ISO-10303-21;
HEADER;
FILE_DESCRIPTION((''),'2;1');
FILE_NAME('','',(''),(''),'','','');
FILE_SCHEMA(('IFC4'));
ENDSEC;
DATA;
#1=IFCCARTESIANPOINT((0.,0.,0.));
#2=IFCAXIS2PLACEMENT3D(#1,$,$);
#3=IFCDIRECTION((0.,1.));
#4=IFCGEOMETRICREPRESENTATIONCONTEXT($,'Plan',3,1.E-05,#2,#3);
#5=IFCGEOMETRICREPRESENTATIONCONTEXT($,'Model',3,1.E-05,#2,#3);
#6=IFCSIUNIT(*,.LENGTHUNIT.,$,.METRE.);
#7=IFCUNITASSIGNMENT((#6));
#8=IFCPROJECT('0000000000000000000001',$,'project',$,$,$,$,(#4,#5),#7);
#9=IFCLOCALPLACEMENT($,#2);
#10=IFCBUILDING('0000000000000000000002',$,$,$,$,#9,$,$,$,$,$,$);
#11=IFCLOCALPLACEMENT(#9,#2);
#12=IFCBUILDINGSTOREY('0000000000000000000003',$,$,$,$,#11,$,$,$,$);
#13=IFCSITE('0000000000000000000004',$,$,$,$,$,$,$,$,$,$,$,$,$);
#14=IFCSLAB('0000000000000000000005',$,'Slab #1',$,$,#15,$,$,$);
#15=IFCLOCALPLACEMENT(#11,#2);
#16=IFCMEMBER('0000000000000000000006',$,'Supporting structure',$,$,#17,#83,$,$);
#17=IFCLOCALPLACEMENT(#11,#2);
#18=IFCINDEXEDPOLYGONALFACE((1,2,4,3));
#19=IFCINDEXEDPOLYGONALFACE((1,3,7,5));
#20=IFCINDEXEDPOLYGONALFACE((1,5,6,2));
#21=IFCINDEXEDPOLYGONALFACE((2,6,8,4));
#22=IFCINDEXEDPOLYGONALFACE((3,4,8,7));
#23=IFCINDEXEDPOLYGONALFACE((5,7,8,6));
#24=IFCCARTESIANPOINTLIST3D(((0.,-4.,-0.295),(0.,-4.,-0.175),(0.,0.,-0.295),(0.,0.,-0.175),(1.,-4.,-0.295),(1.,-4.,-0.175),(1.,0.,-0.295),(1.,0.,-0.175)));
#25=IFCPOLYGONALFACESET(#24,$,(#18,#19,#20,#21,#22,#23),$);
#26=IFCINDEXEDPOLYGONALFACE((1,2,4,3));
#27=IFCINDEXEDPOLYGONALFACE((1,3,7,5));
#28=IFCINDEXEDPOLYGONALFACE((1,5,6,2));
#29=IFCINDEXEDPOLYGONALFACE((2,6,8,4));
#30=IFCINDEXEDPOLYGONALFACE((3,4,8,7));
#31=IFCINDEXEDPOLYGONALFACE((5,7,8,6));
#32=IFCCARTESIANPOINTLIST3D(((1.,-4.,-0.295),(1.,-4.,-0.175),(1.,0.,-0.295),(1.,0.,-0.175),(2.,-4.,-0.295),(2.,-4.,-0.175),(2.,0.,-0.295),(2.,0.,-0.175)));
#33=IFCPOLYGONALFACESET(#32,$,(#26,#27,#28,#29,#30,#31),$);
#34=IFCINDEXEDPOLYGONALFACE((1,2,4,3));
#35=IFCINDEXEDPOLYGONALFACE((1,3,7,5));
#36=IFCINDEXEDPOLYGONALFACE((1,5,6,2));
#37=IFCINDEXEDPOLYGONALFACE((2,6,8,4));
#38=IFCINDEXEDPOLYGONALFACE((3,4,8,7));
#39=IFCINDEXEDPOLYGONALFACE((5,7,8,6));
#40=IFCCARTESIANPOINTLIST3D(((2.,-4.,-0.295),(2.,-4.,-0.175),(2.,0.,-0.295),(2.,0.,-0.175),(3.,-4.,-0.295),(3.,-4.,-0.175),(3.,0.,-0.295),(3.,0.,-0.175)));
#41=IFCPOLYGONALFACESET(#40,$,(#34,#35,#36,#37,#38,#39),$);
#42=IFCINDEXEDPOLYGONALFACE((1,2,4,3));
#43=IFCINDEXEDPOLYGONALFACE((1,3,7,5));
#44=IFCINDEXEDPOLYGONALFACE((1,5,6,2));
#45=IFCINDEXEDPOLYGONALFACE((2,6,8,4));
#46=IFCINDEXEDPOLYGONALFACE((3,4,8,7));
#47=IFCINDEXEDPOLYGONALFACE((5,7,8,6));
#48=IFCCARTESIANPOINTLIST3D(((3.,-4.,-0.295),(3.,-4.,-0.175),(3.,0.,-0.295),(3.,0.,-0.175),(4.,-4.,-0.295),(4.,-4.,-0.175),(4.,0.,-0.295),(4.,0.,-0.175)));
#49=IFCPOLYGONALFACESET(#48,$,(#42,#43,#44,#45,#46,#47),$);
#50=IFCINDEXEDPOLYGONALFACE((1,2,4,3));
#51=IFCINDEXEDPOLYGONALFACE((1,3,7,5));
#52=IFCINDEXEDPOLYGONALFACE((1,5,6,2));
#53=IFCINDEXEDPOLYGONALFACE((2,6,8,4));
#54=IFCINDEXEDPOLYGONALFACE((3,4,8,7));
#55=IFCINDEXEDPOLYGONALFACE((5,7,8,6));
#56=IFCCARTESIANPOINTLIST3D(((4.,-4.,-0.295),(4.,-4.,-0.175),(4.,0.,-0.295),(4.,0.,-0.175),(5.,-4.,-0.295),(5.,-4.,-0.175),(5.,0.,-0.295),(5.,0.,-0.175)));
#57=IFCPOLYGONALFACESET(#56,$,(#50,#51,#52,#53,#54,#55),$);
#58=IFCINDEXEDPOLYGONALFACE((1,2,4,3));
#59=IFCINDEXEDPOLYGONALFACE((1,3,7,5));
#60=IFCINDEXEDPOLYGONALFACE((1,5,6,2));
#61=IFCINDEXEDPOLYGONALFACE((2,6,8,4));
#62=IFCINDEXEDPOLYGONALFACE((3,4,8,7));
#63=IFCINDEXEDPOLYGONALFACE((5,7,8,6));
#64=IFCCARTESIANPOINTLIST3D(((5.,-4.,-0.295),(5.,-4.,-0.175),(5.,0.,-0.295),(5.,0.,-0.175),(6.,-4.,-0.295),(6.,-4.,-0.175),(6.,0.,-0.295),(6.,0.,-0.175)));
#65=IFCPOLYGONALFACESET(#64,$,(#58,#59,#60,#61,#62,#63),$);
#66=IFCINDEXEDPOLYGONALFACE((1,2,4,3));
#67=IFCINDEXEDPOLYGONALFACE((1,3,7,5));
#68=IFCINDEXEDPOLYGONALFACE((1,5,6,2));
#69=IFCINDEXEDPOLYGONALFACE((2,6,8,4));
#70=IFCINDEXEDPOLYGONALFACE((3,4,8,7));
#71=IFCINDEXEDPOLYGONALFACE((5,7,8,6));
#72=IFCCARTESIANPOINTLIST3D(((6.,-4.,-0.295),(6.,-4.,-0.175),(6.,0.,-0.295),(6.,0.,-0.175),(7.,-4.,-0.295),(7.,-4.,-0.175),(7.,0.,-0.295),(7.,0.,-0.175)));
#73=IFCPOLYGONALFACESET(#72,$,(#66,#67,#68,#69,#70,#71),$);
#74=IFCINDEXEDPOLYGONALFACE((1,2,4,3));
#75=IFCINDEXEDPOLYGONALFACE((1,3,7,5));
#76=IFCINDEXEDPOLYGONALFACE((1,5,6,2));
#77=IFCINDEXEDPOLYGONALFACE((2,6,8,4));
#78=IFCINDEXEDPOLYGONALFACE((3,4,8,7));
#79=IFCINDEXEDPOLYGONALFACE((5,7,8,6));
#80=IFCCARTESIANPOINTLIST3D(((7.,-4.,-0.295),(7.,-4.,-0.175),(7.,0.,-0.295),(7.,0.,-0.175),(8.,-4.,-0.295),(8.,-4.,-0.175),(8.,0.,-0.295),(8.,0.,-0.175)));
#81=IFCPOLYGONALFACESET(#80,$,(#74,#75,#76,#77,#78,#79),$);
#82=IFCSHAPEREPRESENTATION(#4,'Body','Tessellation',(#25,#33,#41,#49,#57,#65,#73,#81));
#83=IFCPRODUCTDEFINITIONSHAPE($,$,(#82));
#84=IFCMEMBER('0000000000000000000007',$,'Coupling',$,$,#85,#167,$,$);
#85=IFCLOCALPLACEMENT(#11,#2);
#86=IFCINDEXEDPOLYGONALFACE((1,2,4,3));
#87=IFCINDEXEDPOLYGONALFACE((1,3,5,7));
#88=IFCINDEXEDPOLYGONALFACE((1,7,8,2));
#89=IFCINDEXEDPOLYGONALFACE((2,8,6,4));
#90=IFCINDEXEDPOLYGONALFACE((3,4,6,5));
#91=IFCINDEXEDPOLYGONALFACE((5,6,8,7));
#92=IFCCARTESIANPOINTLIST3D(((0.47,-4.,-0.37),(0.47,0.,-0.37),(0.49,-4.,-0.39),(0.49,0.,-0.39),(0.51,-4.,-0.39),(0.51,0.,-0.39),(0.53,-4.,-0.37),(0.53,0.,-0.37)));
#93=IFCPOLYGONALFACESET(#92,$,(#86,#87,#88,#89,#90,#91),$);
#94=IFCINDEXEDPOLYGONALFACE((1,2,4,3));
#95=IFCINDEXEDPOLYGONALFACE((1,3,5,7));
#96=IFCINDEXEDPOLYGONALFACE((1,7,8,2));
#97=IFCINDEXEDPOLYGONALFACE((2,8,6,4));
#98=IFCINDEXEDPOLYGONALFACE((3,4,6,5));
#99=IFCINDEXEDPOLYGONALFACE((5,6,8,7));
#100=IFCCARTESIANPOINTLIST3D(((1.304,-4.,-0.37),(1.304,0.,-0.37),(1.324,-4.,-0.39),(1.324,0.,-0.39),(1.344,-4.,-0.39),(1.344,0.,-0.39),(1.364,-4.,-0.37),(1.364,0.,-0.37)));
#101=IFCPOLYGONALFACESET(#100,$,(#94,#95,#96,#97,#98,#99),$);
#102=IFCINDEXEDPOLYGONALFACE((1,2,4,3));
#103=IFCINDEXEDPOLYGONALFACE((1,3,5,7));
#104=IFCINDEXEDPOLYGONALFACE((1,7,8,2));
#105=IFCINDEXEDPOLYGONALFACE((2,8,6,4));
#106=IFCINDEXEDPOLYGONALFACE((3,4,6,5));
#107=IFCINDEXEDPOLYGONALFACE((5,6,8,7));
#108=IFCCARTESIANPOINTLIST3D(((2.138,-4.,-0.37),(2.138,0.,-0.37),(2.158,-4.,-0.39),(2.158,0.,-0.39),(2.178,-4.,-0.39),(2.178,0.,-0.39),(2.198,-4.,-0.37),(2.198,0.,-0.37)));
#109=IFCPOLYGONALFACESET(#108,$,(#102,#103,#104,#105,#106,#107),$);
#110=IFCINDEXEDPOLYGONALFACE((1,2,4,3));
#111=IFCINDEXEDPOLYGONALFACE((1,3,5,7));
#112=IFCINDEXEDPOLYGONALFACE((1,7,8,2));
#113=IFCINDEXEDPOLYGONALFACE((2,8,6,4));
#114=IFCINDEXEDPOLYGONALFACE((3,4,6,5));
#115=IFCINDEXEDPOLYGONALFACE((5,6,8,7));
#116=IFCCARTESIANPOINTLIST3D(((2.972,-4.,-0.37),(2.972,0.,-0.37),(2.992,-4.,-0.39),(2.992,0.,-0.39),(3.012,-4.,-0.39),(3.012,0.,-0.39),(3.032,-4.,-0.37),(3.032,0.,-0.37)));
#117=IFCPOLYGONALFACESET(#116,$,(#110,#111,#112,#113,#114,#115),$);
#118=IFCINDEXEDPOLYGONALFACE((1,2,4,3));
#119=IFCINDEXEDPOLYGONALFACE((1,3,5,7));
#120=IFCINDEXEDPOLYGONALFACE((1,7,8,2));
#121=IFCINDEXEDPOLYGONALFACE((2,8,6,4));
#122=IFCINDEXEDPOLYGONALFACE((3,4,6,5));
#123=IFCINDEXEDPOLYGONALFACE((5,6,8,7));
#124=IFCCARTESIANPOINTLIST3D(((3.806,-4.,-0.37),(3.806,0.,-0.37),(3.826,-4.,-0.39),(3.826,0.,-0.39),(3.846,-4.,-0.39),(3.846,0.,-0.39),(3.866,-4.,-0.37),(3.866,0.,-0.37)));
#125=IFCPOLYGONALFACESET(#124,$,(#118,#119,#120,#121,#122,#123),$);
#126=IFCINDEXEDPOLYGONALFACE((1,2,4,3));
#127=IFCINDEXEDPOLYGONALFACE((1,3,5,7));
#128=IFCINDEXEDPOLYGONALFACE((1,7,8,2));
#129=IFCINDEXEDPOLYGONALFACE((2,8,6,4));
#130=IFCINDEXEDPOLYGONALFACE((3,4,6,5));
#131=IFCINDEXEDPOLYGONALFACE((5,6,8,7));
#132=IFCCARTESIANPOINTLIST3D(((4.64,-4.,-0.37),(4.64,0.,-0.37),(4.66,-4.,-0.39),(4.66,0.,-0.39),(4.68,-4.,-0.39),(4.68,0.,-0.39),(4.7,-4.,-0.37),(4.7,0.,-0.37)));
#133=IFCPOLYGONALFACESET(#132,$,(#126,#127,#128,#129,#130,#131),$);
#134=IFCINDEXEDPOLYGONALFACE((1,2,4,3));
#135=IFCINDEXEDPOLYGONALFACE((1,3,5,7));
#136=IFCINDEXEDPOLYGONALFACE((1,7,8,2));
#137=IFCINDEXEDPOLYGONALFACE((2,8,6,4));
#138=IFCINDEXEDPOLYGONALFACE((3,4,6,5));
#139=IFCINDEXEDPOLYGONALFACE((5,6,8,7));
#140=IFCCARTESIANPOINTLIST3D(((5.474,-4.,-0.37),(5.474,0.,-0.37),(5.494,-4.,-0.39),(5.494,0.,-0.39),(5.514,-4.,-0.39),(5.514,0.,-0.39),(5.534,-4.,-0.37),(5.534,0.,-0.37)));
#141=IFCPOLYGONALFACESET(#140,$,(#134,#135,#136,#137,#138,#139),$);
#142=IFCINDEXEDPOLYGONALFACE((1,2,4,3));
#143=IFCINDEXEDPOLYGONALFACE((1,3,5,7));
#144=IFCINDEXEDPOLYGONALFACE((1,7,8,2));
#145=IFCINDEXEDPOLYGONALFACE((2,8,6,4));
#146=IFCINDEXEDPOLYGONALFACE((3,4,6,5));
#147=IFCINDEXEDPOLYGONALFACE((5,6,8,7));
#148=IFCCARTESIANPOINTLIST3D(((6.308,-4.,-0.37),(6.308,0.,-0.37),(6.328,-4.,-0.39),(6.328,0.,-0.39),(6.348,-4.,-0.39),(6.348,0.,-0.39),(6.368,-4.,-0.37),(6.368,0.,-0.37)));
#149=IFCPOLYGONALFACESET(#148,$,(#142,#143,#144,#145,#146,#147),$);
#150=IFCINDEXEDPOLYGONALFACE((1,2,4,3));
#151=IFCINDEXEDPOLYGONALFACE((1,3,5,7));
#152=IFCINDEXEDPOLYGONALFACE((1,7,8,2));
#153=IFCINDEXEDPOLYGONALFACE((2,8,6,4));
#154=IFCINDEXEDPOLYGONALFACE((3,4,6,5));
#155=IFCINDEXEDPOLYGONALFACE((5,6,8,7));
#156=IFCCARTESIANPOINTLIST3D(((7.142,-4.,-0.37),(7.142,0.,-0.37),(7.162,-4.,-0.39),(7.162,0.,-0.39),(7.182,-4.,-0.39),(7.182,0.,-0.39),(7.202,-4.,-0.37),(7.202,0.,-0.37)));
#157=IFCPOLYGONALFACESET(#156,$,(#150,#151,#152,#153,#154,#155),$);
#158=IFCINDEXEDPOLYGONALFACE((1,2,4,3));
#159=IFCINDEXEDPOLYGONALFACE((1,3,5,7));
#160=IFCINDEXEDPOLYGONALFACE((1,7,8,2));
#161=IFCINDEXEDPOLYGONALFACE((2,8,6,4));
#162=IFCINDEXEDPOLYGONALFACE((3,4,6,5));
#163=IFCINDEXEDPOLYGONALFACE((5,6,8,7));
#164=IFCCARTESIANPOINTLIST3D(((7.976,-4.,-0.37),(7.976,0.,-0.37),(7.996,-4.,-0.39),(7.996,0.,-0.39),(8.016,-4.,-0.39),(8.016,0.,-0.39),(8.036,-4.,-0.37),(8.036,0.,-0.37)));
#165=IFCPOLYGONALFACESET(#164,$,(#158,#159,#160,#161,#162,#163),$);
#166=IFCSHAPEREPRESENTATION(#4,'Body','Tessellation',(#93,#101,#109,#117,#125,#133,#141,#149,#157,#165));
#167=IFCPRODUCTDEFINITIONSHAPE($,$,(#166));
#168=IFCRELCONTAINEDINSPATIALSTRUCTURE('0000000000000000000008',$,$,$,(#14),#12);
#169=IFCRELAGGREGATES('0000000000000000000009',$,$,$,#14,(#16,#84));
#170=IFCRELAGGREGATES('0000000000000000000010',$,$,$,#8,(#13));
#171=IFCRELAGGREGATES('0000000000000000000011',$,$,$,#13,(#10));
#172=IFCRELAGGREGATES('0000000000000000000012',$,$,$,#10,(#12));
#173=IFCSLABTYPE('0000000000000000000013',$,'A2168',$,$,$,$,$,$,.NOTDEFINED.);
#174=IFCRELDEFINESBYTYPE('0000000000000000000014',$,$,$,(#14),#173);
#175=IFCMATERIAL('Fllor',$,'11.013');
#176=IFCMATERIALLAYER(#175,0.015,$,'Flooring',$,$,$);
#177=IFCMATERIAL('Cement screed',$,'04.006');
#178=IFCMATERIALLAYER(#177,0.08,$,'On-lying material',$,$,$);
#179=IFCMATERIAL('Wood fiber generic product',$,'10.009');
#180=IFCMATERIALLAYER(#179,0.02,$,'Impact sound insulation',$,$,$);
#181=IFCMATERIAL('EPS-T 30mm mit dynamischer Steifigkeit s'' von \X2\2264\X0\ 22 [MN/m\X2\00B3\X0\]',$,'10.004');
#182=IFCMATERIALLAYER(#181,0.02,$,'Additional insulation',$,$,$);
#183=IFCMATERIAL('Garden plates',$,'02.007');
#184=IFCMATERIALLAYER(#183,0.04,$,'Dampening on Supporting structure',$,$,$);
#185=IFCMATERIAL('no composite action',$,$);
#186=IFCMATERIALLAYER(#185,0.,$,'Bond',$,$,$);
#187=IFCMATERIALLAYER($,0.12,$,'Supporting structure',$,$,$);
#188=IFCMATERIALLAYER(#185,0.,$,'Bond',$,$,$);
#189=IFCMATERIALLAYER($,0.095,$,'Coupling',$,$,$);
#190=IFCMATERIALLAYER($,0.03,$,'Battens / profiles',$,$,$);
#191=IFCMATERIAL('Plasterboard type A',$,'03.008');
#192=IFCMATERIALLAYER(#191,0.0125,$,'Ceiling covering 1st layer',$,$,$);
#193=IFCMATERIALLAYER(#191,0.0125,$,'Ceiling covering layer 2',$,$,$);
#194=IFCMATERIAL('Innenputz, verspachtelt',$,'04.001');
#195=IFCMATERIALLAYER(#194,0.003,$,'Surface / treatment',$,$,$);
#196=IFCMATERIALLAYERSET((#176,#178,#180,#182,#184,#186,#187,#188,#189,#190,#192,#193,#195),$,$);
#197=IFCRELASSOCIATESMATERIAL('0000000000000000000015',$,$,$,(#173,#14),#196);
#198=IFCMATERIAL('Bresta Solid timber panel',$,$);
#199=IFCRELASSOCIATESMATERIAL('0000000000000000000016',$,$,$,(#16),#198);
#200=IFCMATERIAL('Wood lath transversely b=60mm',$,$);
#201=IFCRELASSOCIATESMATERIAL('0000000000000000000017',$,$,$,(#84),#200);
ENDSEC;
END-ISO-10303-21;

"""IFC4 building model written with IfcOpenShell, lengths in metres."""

from ifc_helpers import new_model, si_unit, direction, frame, frame_2d, origin, place, context, project, spatial, polyline, rectangle, outline, extrude, material, layer, layer_set, type_object, element, aggregate, save


model = new_model("IFC4")

# Units and contexts
plan_context = context("Plan", 3, precision=1e-05, world=origin(), true_north=direction((0.0, 1.0)))
model_context = context("Model", 3, precision=1e-05, world=origin(), true_north=direction((0.0, 1.0)))
ifc_project = project(units=[si_unit("LENGTHUNIT", "METRE")], contexts=[plan_context, model_context])

# Site, building, storey
site = spatial("IfcSite", under=ifc_project)
building_placement = place(None, origin())
building = spatial("IfcBuilding", under=site, at=building_placement)
storey_placement = place(building_placement, origin())
storey = spatial("IfcBuildingStorey", under=building, at=storey_placement)

# Slab, members
ifc_material_1 = material(Name="Fllor", Category="11.013")
ifc_layer_1 = layer(ifc_material_1, 0.015, Name="Flooring")
ifc_material_2 = material(Name="Cement screed", Category="04.006")
ifc_layer_2 = layer(ifc_material_2, 0.08, Name="On-lying material")
ifc_material_3 = material(Name="Wood fiber generic product", Category="10.009")
ifc_layer_3 = layer(ifc_material_3, 0.02, Name="Impact sound insulation")
ifc_material_4 = material(Name="EPS-T 30mm mit dynamischer Steifigkeit s' von ≤ 22 [MN/m³]", Category="10.004")
ifc_layer_4 = layer(ifc_material_4, 0.02, Name="Additional insulation")
ifc_material_5 = material(Name="Garden plates", Category="02.007")
ifc_layer_5 = layer(ifc_material_5, 0.04, Name="Dampening on Supporting structure")
ifc_material_6 = material(Name="no composite action")
ifc_layer_6 = layer(ifc_material_6, 0.0, Name="Bond")
ifc_layer_7 = layer(None, 0.12, Name="Supporting structure")
ifc_layer_8 = layer(ifc_material_6, 0.0, Name="Bond")
ifc_layer_9 = layer(None, 0.095, Name="Coupling")
ifc_layer_10 = layer(None, 0.03, Name="Battens / profiles")
ifc_material_7 = material(Name="Plasterboard type A", Category="03.008")
ifc_layer_11 = layer(ifc_material_7, 0.0125, Name="Ceiling covering 1st layer")
ifc_layer_12 = layer(ifc_material_7, 0.0125, Name="Ceiling covering layer 2")
ifc_material_8 = material(Name="Innenputz, verspachtelt", Category="04.001")
ifc_layer_13 = layer(ifc_material_8, 0.003, Name="Surface / treatment")
ifc_layer_set = layer_set([ifc_layer_1, ifc_layer_2, ifc_layer_3, ifc_layer_4, ifc_layer_5, ifc_layer_6, ifc_layer_7, ifc_layer_8, ifc_layer_9, ifc_layer_10, ifc_layer_11, ifc_layer_12, ifc_layer_13])
slab_type = type_object("IfcSlabType", Name="A2168", PredefinedType="NOTDEFINED", material=ifc_layer_set)
slab_placement = place(None, frame((0.0, 0.0, 0.0), z_axis=(0.0, 0.0, -1.0), x_axis=(1.0, 0.0, 0.0)))
slab = element("IfcSlab", 1, at=slab_placement, inside=storey, type_object=slab_type, material=ifc_layer_set, Name="Slab #1")
ifc_material_9 = material(Name="Bresta Solid timber panel")
member_1_placement = place(slab_placement, origin())
member_1 = element("IfcMember", 2, at=member_1_placement, material=ifc_material_9, Name="Supporting structure", context=plan_context, shape_type="SweptSolid", body=[
    extrude(rectangle(XDim=1.0, YDim=0.12, at=frame_2d((0.5, 0.06), x_axis=(1.0, 0.0))), frame((0.0, 4.0, 0.175), z_axis=(0.0, -1.0, 0.0), x_axis=(1.0, 0.0, 0.0)), (0.0, 0.0, 1.0), 4.0),
    extrude(rectangle(XDim=1.0, YDim=0.12, at=frame_2d((0.5, 0.06), x_axis=(1.0, 0.0))), frame((1.0, 4.0, 0.175), z_axis=(0.0, -1.0, 0.0), x_axis=(1.0, 0.0, 0.0)), (0.0, 0.0, 1.0), 4.0),
    extrude(rectangle(XDim=1.0, YDim=0.12, at=frame_2d((0.5, 0.06), x_axis=(1.0, 0.0))), frame((2.0, 4.0, 0.175), z_axis=(0.0, -1.0, 0.0), x_axis=(1.0, 0.0, 0.0)), (0.0, 0.0, 1.0), 4.0),
    extrude(rectangle(XDim=1.0, YDim=0.12, at=frame_2d((0.5, 0.06), x_axis=(1.0, 0.0))), frame((3.0, 4.0, 0.175), z_axis=(0.0, -1.0, 0.0), x_axis=(1.0, 0.0, 0.0)), (0.0, 0.0, 1.0), 4.0),
    extrude(rectangle(XDim=1.0, YDim=0.12, at=frame_2d((0.5, 0.06), x_axis=(1.0, 0.0))), frame((4.0, 4.0, 0.175), z_axis=(0.0, -1.0, 0.0), x_axis=(1.0, 0.0, 0.0)), (0.0, 0.0, 1.0), 4.0),
    extrude(rectangle(XDim=1.0, YDim=0.12, at=frame_2d((0.5, 0.06), x_axis=(1.0, 0.0))), frame((5.0, 4.0, 0.175), z_axis=(0.0, -1.0, 0.0), x_axis=(1.0, 0.0, 0.0)), (0.0, 0.0, 1.0), 4.0),
    extrude(rectangle(XDim=1.0, YDim=0.12, at=frame_2d((0.5, 0.06), x_axis=(1.0, 0.0))), frame((6.0, 4.0, 0.175), z_axis=(0.0, -1.0, 0.0), x_axis=(1.0, 0.0, 0.0)), (0.0, 0.0, 1.0), 4.0),
    extrude(rectangle(XDim=1.0, YDim=0.12, at=frame_2d((0.5, 0.06), x_axis=(1.0, 0.0))), frame((7.0, 4.0, 0.175), z_axis=(0.0, -1.0, 0.0), x_axis=(1.0, 0.0, 0.0)), (0.0, 0.0, 1.0), 4.0),
])
ifc_material_10 = material(Name="Wood lath transversely b=60mm")
member_2_placement = place(slab_placement, origin())
member_2 = element("IfcMember", 3, at=member_2_placement, material=ifc_material_10, Name="Coupling", context=plan_context, shape_type="SweptSolid", body=[
    extrude(outline(polyline([(0.0, 0.0), (0.06, 0.0), (0.04, 0.02), (0.02, 0.02), (0.0, 0.0)])), frame((0.47, 4.0, 0.37), z_axis=(0.0, -1.0, 0.0), x_axis=(1.0, 0.0, 0.0)), (0.0, 0.0, 1.0), 4.0),
    extrude(outline(polyline([(0.0, 0.0), (0.06, 0.0), (0.04, 0.02), (0.02, 0.02), (0.0, 0.0)])), frame((1.304, 4.0, 0.37), z_axis=(0.0, -1.0, 0.0), x_axis=(1.0, 0.0, 0.0)), (0.0, 0.0, 1.0), 4.0),
    extrude(outline(polyline([(0.0, 0.0), (0.06, 0.0), (0.04, 0.02), (0.02, 0.02), (0.0, 0.0)])), frame((2.138, 4.0, 0.37), z_axis=(0.0, -1.0, 0.0), x_axis=(1.0, 0.0, 0.0)), (0.0, 0.0, 1.0), 4.0),
    extrude(outline(polyline([(0.0, 0.0), (0.06, 0.0), (0.04, 0.02), (0.02, 0.02), (0.0, 0.0)])), frame((2.972, 4.0, 0.37), z_axis=(0.0, -1.0, 0.0), x_axis=(1.0, 0.0, 0.0)), (0.0, 0.0, 1.0), 4.0),
    extrude(outline(polyline([(0.0, 0.0), (0.06, 0.0), (0.04, 0.02), (0.02, 0.02), (0.0, 0.0)])), frame((3.806, 4.0, 0.37), z_axis=(0.0, -1.0, 0.0), x_axis=(1.0, 0.0, 0.0)), (0.0, 0.0, 1.0), 4.0),
    extrude(outline(polyline([(0.0, 0.0), (0.06, 0.0), (0.04, 0.02), (0.02, 0.02), (0.0, 0.0)])), frame((4.64, 4.0, 0.37), z_axis=(0.0, -1.0, 0.0), x_axis=(1.0, 0.0, 0.0)), (0.0, 0.0, 1.0), 4.0),
    extrude(outline(polyline([(0.0, 0.0), (0.06, 0.0), (0.04, 0.02), (0.02, 0.02), (0.0, 0.0)])), frame((5.474, 4.0, 0.37), z_axis=(0.0, -1.0, 0.0), x_axis=(1.0, 0.0, 0.0)), (0.0, 0.0, 1.0), 4.0),
    extrude(outline(polyline([(0.0, 0.0), (0.06, 0.0), (0.04, 0.02), (0.02, 0.02), (0.0, 0.0)])), frame((6.308, 4.0, 0.37), z_axis=(0.0, -1.0, 0.0), x_axis=(1.0, 0.0, 0.0)), (0.0, 0.0, 1.0), 4.0),
    extrude(outline(polyline([(0.0, 0.0), (0.06, 0.0), (0.04, 0.02), (0.02, 0.02), (0.0, 0.0)])), frame((7.142, 4.0, 0.37), z_axis=(0.0, -1.0, 0.0), x_axis=(1.0, 0.0, 0.0)), (0.0, 0.0, 1.0), 4.0),
    extrude(outline(polyline([(0.0, 0.0), (0.06, 0.0), (0.04, 0.02), (0.02, 0.02), (0.0, 0.0)])), frame((7.976, 4.0, 0.37), z_axis=(0.0, -1.0, 0.0), x_axis=(1.0, 0.0, 0.0)), (0.0, 0.0, 1.0), 4.0),
])
aggregate(slab, [member_1, member_2])

save(model, "model.ifc")
